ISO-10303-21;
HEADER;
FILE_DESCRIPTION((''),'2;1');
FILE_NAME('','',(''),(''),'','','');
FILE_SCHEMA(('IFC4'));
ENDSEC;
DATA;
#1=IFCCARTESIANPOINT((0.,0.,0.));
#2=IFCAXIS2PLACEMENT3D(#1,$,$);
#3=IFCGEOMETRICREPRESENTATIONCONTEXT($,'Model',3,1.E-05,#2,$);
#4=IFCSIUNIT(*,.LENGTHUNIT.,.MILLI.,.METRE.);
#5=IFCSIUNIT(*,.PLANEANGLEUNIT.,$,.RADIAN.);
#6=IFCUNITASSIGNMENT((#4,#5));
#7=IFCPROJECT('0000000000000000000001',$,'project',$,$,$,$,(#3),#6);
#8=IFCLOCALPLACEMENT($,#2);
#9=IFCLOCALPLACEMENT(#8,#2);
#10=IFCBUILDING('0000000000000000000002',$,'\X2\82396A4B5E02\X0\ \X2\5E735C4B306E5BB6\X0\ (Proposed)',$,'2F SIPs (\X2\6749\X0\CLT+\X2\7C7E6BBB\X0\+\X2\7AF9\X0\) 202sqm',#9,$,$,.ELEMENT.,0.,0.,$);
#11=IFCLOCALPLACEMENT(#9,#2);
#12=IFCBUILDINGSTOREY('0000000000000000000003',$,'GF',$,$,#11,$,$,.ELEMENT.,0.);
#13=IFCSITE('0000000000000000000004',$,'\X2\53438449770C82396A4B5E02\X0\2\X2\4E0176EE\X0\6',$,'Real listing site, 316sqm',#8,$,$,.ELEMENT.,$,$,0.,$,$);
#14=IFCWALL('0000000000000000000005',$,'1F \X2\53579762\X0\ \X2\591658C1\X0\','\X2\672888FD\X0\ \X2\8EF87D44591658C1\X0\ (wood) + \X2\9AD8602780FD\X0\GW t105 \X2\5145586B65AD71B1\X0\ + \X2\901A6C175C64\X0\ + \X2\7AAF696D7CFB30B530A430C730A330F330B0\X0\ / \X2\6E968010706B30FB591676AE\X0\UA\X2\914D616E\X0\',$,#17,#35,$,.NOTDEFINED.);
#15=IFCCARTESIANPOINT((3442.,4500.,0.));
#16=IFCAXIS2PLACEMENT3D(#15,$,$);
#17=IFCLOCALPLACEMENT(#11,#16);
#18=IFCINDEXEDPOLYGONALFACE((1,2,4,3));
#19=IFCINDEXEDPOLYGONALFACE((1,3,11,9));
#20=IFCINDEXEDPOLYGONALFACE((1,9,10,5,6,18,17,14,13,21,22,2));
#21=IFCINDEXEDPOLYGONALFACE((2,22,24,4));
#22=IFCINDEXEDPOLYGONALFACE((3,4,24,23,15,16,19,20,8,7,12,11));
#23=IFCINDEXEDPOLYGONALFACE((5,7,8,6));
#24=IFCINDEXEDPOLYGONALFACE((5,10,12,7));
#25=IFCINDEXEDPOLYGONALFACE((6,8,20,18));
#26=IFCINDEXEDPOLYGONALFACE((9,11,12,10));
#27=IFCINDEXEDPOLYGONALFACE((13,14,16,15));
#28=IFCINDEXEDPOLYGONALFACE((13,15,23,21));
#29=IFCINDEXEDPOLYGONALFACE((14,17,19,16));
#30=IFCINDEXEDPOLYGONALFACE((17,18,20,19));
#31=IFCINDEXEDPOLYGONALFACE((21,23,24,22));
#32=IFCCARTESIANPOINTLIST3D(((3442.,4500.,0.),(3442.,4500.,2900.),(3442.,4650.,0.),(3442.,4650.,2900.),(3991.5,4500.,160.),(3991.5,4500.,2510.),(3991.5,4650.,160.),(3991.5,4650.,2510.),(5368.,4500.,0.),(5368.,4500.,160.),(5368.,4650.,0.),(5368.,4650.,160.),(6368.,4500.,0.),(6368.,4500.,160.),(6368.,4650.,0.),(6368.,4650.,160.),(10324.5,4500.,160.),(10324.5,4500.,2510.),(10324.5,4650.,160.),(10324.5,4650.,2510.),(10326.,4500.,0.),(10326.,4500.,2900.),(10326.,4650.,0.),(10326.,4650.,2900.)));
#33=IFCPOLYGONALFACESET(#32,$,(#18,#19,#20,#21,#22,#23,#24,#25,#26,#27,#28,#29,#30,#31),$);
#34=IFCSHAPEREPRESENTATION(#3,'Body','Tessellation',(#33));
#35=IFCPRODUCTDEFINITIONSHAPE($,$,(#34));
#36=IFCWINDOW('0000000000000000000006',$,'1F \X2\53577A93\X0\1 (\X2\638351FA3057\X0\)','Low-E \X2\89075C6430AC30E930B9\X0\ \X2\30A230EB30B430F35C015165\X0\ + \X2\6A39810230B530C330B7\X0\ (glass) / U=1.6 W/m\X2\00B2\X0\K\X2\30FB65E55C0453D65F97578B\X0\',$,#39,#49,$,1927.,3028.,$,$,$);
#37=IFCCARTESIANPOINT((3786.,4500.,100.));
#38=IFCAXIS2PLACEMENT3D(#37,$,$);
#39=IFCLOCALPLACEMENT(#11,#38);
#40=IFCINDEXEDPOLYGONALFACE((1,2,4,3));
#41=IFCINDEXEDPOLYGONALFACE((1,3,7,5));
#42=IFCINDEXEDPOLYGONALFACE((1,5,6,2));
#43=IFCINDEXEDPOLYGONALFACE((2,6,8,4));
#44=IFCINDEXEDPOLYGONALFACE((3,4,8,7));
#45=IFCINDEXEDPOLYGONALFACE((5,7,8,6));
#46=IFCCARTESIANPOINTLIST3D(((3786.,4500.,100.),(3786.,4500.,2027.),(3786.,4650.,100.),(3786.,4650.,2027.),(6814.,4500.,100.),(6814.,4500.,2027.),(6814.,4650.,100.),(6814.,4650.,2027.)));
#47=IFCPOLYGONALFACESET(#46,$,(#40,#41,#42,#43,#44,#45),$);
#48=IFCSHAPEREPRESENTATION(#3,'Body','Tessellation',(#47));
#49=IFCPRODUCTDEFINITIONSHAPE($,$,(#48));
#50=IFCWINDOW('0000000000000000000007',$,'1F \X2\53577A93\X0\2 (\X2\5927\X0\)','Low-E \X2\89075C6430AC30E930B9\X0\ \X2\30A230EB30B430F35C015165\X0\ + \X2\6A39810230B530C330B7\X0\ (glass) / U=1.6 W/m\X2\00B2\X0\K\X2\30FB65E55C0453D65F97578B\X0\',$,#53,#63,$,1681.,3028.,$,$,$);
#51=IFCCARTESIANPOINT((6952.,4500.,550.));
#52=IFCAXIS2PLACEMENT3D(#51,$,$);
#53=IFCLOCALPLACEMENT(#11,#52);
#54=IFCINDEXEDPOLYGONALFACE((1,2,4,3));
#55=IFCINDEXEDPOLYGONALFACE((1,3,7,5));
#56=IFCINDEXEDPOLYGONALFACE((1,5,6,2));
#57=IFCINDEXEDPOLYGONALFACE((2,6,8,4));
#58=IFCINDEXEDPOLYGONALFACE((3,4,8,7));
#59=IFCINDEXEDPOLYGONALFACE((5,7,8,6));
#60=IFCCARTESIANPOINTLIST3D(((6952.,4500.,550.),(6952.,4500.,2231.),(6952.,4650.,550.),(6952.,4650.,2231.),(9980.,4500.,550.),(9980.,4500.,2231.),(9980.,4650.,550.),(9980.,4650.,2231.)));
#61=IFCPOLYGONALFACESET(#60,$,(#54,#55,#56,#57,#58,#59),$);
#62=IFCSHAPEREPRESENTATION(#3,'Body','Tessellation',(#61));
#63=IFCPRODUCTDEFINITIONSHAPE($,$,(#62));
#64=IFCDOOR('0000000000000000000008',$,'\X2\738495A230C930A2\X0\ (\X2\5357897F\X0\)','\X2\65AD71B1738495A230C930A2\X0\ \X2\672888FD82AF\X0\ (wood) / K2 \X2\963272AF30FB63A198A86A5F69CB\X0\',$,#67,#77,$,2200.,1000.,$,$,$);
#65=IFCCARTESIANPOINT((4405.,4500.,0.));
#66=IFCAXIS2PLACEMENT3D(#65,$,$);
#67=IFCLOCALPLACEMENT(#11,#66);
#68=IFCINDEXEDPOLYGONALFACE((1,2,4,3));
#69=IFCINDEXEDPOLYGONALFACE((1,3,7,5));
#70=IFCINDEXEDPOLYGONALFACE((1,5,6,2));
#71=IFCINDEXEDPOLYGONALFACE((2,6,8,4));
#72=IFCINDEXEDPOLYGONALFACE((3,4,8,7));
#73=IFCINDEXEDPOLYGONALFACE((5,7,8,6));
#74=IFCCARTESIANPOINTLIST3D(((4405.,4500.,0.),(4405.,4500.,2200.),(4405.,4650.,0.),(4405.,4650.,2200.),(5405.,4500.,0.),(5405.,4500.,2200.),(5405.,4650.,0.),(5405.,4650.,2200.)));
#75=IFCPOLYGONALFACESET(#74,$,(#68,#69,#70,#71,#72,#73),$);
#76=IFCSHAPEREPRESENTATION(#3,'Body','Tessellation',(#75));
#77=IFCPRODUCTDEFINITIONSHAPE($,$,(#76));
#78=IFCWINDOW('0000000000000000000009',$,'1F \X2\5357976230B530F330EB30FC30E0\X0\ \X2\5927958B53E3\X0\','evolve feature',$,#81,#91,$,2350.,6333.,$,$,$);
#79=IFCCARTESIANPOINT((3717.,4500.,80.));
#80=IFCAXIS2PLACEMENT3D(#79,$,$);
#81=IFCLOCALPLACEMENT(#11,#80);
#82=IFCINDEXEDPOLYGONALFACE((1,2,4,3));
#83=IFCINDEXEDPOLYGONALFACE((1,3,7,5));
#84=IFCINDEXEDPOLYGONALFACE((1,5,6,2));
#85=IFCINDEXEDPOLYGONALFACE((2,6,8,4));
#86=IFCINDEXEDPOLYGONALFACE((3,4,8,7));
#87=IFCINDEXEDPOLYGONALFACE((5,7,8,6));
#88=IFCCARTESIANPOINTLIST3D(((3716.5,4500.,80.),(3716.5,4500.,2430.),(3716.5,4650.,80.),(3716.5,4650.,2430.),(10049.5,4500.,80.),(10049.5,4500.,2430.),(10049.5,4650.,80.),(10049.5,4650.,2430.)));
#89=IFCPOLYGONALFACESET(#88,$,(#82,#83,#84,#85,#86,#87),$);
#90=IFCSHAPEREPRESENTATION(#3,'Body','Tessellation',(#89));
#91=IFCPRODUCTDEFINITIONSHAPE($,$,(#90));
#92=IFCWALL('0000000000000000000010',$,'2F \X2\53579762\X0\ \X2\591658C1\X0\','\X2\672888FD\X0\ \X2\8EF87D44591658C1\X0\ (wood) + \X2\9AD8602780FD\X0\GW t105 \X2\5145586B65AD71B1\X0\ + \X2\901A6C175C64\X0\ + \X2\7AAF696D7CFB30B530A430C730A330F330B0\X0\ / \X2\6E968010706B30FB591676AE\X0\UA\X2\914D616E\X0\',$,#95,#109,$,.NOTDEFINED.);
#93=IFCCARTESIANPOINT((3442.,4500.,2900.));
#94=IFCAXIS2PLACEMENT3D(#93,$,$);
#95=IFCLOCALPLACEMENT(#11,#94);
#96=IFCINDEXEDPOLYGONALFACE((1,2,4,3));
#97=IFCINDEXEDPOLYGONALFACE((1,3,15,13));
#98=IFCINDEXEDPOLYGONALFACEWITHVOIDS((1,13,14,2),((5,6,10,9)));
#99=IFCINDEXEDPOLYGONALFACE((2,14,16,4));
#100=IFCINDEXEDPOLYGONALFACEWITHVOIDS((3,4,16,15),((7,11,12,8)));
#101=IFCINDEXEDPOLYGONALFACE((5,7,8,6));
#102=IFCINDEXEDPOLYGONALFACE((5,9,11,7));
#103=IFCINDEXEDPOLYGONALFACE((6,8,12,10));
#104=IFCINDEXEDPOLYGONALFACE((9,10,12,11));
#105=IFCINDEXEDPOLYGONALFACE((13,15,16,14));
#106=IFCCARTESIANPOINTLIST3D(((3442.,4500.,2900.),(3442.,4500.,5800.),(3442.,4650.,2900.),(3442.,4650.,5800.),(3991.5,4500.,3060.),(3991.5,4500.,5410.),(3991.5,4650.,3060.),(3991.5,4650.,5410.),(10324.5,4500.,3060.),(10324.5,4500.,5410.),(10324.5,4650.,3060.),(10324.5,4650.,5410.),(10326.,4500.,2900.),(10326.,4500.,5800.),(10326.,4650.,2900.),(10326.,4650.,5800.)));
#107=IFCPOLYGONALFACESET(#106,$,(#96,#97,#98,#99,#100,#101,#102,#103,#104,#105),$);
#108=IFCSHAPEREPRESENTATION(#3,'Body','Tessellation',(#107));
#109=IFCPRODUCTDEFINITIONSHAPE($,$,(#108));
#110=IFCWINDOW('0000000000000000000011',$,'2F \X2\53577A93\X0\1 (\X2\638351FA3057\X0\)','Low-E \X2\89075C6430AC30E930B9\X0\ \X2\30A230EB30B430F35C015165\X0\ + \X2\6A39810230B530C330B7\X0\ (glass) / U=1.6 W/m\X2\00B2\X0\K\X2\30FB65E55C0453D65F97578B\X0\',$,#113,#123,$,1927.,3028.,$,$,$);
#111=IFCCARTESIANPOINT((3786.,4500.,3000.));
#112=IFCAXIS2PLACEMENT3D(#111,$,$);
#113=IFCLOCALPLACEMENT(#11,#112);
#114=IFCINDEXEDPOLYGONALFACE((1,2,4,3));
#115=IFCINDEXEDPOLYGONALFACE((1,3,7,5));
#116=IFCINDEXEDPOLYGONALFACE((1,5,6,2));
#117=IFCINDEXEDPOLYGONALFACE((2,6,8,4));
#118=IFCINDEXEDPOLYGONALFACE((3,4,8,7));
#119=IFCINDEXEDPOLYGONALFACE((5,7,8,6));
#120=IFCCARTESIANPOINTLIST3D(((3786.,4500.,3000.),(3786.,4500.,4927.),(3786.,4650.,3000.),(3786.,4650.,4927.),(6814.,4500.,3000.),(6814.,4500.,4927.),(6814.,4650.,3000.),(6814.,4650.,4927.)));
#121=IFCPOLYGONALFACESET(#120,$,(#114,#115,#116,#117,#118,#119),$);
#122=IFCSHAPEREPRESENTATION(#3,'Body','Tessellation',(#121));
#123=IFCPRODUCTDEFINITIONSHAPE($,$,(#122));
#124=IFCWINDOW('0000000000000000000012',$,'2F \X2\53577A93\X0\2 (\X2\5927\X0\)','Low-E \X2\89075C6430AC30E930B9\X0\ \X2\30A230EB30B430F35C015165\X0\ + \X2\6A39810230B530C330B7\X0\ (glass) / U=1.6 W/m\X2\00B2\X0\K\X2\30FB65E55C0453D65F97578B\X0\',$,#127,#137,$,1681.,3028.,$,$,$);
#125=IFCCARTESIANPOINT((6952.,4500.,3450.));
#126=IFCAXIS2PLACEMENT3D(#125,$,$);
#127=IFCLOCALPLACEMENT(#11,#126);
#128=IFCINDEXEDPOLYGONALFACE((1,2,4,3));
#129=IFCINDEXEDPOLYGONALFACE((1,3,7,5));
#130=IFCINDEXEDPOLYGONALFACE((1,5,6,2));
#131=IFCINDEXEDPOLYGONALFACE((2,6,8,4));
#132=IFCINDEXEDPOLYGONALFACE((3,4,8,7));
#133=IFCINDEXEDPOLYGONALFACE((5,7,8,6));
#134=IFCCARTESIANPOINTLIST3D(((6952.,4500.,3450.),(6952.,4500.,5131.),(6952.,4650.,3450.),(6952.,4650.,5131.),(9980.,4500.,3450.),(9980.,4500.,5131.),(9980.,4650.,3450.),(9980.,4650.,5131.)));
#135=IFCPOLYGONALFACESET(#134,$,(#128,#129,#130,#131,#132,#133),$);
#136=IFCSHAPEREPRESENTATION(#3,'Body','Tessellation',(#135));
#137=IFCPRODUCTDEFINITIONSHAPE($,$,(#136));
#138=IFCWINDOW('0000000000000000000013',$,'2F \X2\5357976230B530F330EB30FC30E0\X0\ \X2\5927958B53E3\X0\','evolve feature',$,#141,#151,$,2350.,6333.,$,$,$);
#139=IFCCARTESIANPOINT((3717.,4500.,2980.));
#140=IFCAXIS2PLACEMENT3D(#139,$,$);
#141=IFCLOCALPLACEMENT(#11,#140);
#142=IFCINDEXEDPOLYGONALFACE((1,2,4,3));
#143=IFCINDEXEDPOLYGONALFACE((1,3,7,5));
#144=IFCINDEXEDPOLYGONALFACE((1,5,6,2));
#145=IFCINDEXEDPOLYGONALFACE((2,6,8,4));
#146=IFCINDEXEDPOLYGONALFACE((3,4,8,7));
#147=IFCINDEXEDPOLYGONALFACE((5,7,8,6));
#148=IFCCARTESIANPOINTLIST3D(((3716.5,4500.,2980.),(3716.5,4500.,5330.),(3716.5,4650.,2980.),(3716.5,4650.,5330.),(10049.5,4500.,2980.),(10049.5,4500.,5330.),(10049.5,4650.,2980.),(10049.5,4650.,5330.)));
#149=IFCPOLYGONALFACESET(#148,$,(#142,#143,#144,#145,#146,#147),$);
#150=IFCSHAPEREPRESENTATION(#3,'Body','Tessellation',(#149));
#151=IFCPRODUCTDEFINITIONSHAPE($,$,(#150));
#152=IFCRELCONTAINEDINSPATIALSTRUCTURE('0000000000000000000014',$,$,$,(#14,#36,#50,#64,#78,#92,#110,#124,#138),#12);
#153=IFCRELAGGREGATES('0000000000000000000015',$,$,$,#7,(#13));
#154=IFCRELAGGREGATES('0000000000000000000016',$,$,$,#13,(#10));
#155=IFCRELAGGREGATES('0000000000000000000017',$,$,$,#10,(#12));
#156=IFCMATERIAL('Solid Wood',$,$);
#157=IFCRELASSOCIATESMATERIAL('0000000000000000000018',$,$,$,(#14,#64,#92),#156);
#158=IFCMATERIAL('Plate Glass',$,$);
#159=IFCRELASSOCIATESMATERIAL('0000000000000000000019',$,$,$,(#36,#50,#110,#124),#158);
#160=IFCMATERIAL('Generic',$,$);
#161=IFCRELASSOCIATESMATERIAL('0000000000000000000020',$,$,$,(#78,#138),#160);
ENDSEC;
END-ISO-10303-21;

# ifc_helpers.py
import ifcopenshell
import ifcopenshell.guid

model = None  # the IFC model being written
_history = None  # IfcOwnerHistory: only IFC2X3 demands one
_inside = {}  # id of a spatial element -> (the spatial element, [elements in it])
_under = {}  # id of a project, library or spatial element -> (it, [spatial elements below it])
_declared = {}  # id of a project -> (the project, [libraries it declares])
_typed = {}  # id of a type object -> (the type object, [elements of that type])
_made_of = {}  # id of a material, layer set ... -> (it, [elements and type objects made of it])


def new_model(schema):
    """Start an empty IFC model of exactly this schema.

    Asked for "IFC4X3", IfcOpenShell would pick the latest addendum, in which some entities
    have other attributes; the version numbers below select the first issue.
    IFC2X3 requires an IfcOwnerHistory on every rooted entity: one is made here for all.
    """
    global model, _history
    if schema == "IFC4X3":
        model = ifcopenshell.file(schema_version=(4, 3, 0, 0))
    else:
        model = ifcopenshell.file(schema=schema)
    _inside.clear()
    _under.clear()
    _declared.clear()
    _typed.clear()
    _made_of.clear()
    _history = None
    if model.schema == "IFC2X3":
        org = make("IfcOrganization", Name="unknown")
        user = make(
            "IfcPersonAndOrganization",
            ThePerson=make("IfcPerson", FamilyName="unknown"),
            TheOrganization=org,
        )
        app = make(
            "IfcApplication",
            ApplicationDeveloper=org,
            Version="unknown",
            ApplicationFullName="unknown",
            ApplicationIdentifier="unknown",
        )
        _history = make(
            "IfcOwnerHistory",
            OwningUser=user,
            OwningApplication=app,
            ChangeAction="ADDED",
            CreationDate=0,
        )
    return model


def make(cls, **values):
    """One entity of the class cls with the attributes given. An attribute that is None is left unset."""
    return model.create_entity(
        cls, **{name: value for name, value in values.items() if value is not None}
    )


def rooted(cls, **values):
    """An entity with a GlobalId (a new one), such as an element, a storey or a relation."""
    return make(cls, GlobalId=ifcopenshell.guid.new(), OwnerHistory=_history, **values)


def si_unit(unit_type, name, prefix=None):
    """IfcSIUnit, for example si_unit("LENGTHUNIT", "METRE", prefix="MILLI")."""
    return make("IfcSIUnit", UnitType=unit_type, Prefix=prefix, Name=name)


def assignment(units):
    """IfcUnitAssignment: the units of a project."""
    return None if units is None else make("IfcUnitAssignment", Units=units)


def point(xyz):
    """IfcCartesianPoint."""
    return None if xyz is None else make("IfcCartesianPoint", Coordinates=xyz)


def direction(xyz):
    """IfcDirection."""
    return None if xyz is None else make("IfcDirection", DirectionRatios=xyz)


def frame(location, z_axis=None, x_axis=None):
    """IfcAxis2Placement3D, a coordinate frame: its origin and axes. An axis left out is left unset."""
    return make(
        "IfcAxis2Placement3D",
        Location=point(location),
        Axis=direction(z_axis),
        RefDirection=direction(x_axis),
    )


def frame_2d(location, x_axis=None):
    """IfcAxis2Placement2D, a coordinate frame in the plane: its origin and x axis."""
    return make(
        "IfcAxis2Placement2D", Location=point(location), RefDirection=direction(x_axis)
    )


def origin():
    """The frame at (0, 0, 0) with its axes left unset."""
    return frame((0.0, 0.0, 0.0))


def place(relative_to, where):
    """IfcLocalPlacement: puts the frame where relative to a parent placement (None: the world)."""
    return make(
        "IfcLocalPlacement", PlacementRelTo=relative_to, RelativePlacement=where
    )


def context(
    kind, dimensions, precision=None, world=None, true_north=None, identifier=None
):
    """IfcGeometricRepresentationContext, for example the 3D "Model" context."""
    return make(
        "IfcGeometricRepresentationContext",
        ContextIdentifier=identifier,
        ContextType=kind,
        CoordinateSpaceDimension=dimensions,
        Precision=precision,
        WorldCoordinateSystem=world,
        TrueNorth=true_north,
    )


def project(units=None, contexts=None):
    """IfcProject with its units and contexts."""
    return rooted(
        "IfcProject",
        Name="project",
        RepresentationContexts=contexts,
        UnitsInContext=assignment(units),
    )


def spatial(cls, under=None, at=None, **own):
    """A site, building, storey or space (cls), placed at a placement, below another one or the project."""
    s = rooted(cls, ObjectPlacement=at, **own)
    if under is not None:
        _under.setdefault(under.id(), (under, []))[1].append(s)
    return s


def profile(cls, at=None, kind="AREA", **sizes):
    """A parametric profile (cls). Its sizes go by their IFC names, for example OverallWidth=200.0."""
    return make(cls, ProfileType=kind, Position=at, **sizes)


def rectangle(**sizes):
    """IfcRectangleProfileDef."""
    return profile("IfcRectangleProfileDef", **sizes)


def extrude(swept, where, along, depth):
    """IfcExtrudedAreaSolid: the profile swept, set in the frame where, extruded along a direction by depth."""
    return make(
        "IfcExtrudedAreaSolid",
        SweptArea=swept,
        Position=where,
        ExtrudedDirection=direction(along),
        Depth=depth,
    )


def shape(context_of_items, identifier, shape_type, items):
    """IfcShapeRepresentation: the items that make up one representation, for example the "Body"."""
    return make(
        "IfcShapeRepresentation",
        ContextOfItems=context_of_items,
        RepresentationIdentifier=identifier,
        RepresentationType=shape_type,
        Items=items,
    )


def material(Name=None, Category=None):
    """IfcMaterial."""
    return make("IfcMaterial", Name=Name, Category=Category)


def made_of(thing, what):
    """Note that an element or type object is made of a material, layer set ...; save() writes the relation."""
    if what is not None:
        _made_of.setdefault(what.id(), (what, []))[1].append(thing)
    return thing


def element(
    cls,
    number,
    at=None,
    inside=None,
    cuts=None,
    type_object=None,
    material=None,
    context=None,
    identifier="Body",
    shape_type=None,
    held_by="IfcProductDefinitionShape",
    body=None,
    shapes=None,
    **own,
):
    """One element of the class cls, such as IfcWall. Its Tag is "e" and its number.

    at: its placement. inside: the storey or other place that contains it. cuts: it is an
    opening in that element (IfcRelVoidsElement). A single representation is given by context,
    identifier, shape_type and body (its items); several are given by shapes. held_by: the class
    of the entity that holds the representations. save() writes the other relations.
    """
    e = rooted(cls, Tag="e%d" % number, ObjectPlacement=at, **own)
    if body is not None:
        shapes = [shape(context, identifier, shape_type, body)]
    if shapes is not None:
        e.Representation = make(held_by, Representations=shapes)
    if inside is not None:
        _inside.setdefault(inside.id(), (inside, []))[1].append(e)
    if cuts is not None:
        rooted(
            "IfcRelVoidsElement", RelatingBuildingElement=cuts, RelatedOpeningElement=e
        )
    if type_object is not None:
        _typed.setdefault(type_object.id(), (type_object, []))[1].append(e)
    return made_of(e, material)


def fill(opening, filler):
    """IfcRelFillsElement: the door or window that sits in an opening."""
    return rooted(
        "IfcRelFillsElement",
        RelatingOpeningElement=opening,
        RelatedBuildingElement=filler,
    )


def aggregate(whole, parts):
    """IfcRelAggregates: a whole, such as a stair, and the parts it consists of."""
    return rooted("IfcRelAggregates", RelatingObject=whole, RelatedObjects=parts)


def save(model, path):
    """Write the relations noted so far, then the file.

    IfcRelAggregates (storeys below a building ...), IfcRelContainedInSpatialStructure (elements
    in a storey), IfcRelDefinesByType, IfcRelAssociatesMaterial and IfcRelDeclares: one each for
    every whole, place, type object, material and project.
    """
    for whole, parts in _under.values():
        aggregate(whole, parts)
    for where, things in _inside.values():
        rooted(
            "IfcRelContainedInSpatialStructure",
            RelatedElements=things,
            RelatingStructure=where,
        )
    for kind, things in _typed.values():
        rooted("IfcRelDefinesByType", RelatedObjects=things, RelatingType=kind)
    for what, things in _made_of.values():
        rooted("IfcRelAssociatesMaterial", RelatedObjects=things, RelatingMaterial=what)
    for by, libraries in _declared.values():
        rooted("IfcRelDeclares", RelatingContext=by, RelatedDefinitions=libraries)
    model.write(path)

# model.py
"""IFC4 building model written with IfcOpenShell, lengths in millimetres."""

from ifc_helpers import new_model, si_unit, frame, frame_2d, origin, place, context, project, spatial, rectangle, extrude, material, element, fill, save


model = new_model("IFC4")

# Units and contexts
model_context = context("Model", 3, precision=1e-05, world=origin())
ifc_project = project(units=[si_unit("LENGTHUNIT", "METRE", prefix="MILLI"), si_unit("PLANEANGLEUNIT", "RADIAN")], contexts=[model_context])

# Site, building, storey
site_placement = place(None, origin())
site = spatial("IfcSite", under=ifc_project, at=site_placement, Name="千葉県船橋市2丁目6", ObjectType="Real listing site, 316sqm", CompositionType="ELEMENT", RefElevation=0.0)
building_placement = place(site_placement, origin())
building = spatial("IfcBuilding", under=site, at=building_placement, Name="船橋市 平屋の家 (Proposed)", ObjectType="2F SIPs (杉CLT+籾殻+竹) 202sqm", CompositionType="ELEMENT", ElevationOfRefHeight=0.0, ElevationOfTerrain=0.0)
storey_placement = place(building_placement, origin())
storey = spatial("IfcBuildingStorey", under=building, at=storey_placement, Name="GF", CompositionType="ELEMENT", Elevation=0.0)

# Shared definitions
ifc_material_1 = material(Name="Solid Wood")

# Wall, openings, windows, door
wall_1_placement = place(storey_placement, frame((3442.0, 4500.0, 0.0)))
wall_1 = element("IfcWall", 1, at=wall_1_placement, inside=storey, material=ifc_material_1, Name="1F 南面 外壁", Description="木製 軸組外壁 (wood) + 高性能GW t105 充填断熱 + 通気層 + 窯業系サイディング / 準耐火・外皮UA配慮", PredefinedType="NOTDEFINED", context=model_context, shape_type="SweptSolid", body=[
    extrude(rectangle(XDim=6884.0, YDim=150.0, at=frame_2d((3442.0, 75.0))), frame((3442.0, 4500.0, 0.0)), (0.0, 0.0, 1.0), 2900.0),
])
opening_1_placement = place(storey_placement, frame((3786.0, 4500.0, 100.0)))
opening_1 = element("IfcOpeningElement", 2, at=opening_1_placement, cuts=wall_1, PredefinedType="NOTDEFINED", context=model_context, shape_type="SweptSolid", body=[
    extrude(rectangle(XDim=3028.0, YDim=150.0, at=frame_2d((1514.0, 75.0))), frame((3786.0, 4500.0, 100.0)), (0.0, 0.0, 1.0), 1927.0),
])
opening_2_placement = place(storey_placement, frame((6952.0, 4500.0, 550.0)))
opening_2 = element("IfcOpeningElement", 3, at=opening_2_placement, cuts=wall_1, PredefinedType="NOTDEFINED", context=model_context, shape_type="SweptSolid", body=[
    extrude(rectangle(XDim=3028.0, YDim=150.0, at=frame_2d((1514.0, 75.0))), frame((6952.0, 4500.0, 550.0)), (0.0, 0.0, 1.0), 1681.0),
])
opening_3_placement = place(storey_placement, frame((4405.0, 4500.0, 0.0)))
opening_3 = element("IfcOpeningElement", 4, at=opening_3_placement, cuts=wall_1, PredefinedType="NOTDEFINED", context=model_context, shape_type="SweptSolid", body=[
    extrude(rectangle(XDim=1000.0, YDim=150.0, at=frame_2d((500.0, 75.0))), frame((4405.0, 4500.0, 0.0)), (0.0, 0.0, 1.0), 2200.0),
])
opening_4_placement = place(storey_placement, frame((3717.0, 4500.0, 80.0)))
opening_4 = element("IfcOpeningElement", 5, at=opening_4_placement, cuts=wall_1, PredefinedType="NOTDEFINED", context=model_context, shape_type="SweptSolid", body=[
    extrude(rectangle(XDim=6333.0, YDim=150.0, at=frame_2d((3166.0, 75.0))), frame((3717.0, 4500.0, 80.0)), (0.0, 0.0, 1.0), 2350.0),
])
ifc_material_2 = material(Name="Plate Glass")
window_1_placement = place(storey_placement, frame((3786.0, 4500.0, 100.0)))
window_1 = element("IfcWindow", 6, at=window_1_placement, inside=storey, material=ifc_material_2, Name="1F 南窓1 (掃出し)", Description="Low-E 複層ガラス アルゴン封入 + 樹脂サッシ (glass) / U=1.6 W/m²K・日射取得型", OverallHeight=1927.0, OverallWidth=3028.0, context=model_context, shape_type="SweptSolid", body=[
    extrude(rectangle(XDim=3028.0, YDim=150.0, at=frame_2d((1514.0, 75.0))), frame((3786.0, 4500.0, 100.0)), (0.0, 0.0, 1.0), 1927.0),
])
fill(opening_1, window_1)
window_2_placement = place(storey_placement, frame((6952.0, 4500.0, 550.0)))
window_2 = element("IfcWindow", 7, at=window_2_placement, inside=storey, material=ifc_material_2, Name="1F 南窓2 (大)", Description="Low-E 複層ガラス アルゴン封入 + 樹脂サッシ (glass) / U=1.6 W/m²K・日射取得型", OverallHeight=1681.0, OverallWidth=3028.0, context=model_context, shape_type="SweptSolid", body=[
    extrude(rectangle(XDim=3028.0, YDim=150.0, at=frame_2d((1514.0, 75.0))), frame((6952.0, 4500.0, 550.0)), (0.0, 0.0, 1.0), 1681.0),
])
fill(opening_2, window_2)
door_placement = place(storey_placement, frame((4405.0, 4500.0, 0.0)))
door = element("IfcDoor", 8, at=door_placement, inside=storey, material=ifc_material_1, Name="玄関ドア (南西)", Description="断熱玄関ドア 木製芯 (wood) / K2 防犯・採風機構", OverallHeight=2200.0, OverallWidth=1000.0, context=model_context, shape_type="SweptSolid", body=[
    extrude(rectangle(XDim=1000.0, YDim=150.0, at=frame_2d((500.0, 75.0))), frame((4405.0, 4500.0, 0.0)), (0.0, 0.0, 1.0), 2200.0),
])
fill(opening_3, door)
ifc_material_3 = material(Name="Generic")
window_3_placement = place(storey_placement, frame((3717.0, 4500.0, 80.0)))
window_3 = element("IfcWindow", 9, at=window_3_placement, inside=storey, material=ifc_material_3, Name="1F 南面サンルーム 大開口", Description="evolve feature", OverallHeight=2350.0, OverallWidth=6333.0, context=model_context, shape_type="SweptSolid", body=[
    extrude(rectangle(XDim=6333.0, YDim=150.0, at=frame_2d((3166.0, 75.0))), frame((3717.0, 4500.0, 80.0)), (0.0, 0.0, 1.0), 2350.0),
])
fill(opening_4, window_3)

# Wall, openings, windows
wall_2_placement = place(storey_placement, frame((3442.0, 4500.0, 2900.0)))
wall_2 = element("IfcWall", 10, at=wall_2_placement, inside=storey, material=ifc_material_1, Name="2F 南面 外壁", Description="木製 軸組外壁 (wood) + 高性能GW t105 充填断熱 + 通気層 + 窯業系サイディング / 準耐火・外皮UA配慮", PredefinedType="NOTDEFINED", context=model_context, shape_type="SweptSolid", body=[
    extrude(rectangle(XDim=6884.0, YDim=150.0, at=frame_2d((3442.0, 75.0))), frame((3442.0, 4500.0, 2900.0)), (0.0, 0.0, 1.0), 2900.0),
])
opening_5_placement = place(storey_placement, frame((3786.0, 4500.0, 3000.0)))
opening_5 = element("IfcOpeningElement", 11, at=opening_5_placement, cuts=wall_2, PredefinedType="NOTDEFINED", context=model_context, shape_type="SweptSolid", body=[
    extrude(rectangle(XDim=3028.0, YDim=150.0, at=frame_2d((1514.0, 75.0))), frame((3786.0, 4500.0, 3000.0)), (0.0, 0.0, 1.0), 1927.0),
])
opening_6_placement = place(storey_placement, frame((6952.0, 4500.0, 3450.0)))
opening_6 = element("IfcOpeningElement", 12, at=opening_6_placement, cuts=wall_2, PredefinedType="NOTDEFINED", context=model_context, shape_type="SweptSolid", body=[
    extrude(rectangle(XDim=3028.0, YDim=150.0, at=frame_2d((1514.0, 75.0))), frame((6952.0, 4500.0, 3450.0)), (0.0, 0.0, 1.0), 1681.0),
])
opening_7_placement = place(storey_placement, frame((3717.0, 4500.0, 2980.0)))
opening_7 = element("IfcOpeningElement", 13, at=opening_7_placement, cuts=wall_2, PredefinedType="NOTDEFINED", context=model_context, shape_type="SweptSolid", body=[
    extrude(rectangle(XDim=6333.0, YDim=150.0, at=frame_2d((3166.0, 75.0))), frame((3717.0, 4500.0, 2980.0)), (0.0, 0.0, 1.0), 2350.0),
])
window_4_placement = place(storey_placement, frame((3786.0, 4500.0, 3000.0)))
window_4 = element("IfcWindow", 14, at=window_4_placement, inside=storey, material=ifc_material_2, Name="2F 南窓1 (掃出し)", Description="Low-E 複層ガラス アルゴン封入 + 樹脂サッシ (glass) / U=1.6 W/m²K・日射取得型", OverallHeight=1927.0, OverallWidth=3028.0, context=model_context, shape_type="SweptSolid", body=[
    extrude(rectangle(XDim=3028.0, YDim=150.0, at=frame_2d((1514.0, 75.0))), frame((3786.0, 4500.0, 3000.0)), (0.0, 0.0, 1.0), 1927.0),
])
fill(opening_5, window_4)
window_5_placement = place(storey_placement, frame((6952.0, 4500.0, 3450.0)))
window_5 = element("IfcWindow", 15, at=window_5_placement, inside=storey, material=ifc_material_2, Name="2F 南窓2 (大)", Description="Low-E 複層ガラス アルゴン封入 + 樹脂サッシ (glass) / U=1.6 W/m²K・日射取得型", OverallHeight=1681.0, OverallWidth=3028.0, context=model_context, shape_type="SweptSolid", body=[
    extrude(rectangle(XDim=3028.0, YDim=150.0, at=frame_2d((1514.0, 75.0))), frame((6952.0, 4500.0, 3450.0)), (0.0, 0.0, 1.0), 1681.0),
])
fill(opening_6, window_5)
window_6_placement = place(storey_placement, frame((3717.0, 4500.0, 2980.0)))
window_6 = element("IfcWindow", 16, at=window_6_placement, inside=storey, material=ifc_material_3, Name="2F 南面サンルーム 大開口", Description="evolve feature", OverallHeight=2350.0, OverallWidth=6333.0, context=model_context, shape_type="SweptSolid", body=[
    extrude(rectangle(XDim=6333.0, YDim=150.0, at=frame_2d((3166.0, 75.0))), frame((3717.0, 4500.0, 2980.0)), (0.0, 0.0, 1.0), 2350.0),
])
fill(opening_7, window_6)

save(model, "model.ifc")
